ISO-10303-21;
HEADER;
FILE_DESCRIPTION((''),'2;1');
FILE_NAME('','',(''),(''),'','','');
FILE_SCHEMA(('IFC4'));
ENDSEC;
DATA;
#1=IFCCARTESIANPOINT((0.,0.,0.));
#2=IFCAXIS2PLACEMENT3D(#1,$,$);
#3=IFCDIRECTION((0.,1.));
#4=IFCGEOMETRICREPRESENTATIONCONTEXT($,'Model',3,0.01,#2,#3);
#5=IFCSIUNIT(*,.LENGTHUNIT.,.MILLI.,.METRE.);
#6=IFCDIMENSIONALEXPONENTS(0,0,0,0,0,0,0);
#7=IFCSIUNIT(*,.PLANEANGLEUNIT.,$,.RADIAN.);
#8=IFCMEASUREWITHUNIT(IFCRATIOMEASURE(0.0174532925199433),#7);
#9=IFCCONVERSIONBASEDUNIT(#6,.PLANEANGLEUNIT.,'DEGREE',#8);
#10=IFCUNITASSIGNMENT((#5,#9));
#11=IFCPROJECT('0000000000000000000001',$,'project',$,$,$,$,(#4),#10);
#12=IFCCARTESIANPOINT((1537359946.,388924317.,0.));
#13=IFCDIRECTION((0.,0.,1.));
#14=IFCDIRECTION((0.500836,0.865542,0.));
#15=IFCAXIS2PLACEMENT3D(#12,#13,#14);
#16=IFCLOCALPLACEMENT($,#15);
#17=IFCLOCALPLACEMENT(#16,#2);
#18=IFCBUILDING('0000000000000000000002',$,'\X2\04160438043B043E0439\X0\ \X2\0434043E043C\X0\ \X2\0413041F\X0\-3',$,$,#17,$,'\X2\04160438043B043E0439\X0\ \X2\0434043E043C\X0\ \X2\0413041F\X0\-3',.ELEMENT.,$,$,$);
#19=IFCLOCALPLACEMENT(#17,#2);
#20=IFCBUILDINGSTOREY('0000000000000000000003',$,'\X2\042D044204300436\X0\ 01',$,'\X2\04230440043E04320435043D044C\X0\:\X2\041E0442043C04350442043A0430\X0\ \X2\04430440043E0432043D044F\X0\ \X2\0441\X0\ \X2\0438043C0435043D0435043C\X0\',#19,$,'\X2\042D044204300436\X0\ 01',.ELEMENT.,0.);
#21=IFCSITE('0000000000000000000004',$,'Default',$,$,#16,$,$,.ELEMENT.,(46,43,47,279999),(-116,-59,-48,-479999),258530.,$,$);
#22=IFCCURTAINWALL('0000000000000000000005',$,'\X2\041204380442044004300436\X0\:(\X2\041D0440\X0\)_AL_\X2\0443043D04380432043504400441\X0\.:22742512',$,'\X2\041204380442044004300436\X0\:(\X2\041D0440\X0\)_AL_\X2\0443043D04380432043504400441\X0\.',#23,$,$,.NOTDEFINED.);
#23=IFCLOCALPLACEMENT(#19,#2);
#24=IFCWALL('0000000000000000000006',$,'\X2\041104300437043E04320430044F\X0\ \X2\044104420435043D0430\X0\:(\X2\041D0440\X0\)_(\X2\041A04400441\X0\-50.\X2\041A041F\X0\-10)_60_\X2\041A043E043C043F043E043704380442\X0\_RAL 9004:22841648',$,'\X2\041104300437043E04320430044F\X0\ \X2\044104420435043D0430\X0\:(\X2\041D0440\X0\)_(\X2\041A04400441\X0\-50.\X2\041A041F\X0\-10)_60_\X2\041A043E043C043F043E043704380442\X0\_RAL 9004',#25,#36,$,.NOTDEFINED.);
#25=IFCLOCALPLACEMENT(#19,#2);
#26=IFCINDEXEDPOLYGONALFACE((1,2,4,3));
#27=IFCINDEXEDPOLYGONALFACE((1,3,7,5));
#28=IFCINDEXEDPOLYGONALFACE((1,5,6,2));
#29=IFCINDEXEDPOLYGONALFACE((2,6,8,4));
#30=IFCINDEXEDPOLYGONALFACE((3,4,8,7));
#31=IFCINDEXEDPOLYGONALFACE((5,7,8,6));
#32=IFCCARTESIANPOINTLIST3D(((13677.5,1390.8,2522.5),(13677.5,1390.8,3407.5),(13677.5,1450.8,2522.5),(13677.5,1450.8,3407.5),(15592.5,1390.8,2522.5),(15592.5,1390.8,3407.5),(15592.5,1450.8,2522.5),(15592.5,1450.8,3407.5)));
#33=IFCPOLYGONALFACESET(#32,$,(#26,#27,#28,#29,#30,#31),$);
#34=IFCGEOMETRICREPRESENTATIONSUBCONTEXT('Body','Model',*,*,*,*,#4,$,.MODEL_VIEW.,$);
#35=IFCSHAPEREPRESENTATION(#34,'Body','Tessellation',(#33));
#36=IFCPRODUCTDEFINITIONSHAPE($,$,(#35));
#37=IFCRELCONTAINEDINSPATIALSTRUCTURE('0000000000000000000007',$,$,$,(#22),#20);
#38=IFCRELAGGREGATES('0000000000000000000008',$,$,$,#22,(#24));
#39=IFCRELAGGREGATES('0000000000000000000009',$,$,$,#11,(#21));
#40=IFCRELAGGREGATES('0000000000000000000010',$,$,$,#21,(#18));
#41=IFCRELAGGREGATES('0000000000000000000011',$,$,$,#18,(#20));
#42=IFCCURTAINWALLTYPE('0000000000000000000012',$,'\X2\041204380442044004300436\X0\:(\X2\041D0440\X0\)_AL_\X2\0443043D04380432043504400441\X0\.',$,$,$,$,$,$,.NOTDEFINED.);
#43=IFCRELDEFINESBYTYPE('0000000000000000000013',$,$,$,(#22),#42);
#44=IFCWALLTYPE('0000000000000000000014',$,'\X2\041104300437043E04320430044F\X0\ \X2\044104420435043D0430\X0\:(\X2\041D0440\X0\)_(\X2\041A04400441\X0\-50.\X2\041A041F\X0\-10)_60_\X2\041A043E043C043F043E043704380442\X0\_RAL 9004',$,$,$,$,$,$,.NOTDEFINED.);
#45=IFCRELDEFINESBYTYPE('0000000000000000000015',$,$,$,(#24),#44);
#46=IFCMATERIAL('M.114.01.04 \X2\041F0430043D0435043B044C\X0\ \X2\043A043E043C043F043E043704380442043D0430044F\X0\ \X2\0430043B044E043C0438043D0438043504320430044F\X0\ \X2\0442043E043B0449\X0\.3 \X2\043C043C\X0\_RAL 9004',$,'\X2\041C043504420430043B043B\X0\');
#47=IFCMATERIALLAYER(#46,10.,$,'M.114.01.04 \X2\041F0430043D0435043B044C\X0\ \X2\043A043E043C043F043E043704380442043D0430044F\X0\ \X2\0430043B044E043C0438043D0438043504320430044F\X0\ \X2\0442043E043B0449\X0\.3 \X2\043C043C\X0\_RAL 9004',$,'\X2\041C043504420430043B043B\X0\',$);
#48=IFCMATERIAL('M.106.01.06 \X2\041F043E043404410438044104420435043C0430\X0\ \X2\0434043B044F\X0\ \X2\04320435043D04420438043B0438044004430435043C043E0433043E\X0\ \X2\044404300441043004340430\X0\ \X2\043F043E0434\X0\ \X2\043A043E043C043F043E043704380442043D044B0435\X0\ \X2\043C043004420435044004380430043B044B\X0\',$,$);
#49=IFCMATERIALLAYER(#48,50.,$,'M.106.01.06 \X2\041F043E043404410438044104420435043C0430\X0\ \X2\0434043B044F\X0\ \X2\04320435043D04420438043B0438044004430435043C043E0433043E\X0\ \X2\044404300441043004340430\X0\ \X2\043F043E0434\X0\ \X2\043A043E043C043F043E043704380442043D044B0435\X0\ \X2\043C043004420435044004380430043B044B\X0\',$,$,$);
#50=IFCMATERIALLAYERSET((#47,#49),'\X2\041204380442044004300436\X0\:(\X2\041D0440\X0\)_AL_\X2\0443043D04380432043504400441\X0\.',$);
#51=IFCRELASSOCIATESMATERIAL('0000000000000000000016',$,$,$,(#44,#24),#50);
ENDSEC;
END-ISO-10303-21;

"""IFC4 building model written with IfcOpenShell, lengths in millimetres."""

from ifc_helpers import new_model, entity, si_unit, converted_unit, direction, frame, frame_2d, origin, place, context, subcontext, project, spatial, rectangle, extrude, material, layer, layer_set, layer_usage, type_object, element, aggregate, save


model = new_model("IFC4")

# Units and contexts
model_context = context("Model", 3, precision=0.01, world=origin(), true_north=direction((0.0, 1.0)))
body_context = subcontext(model_context, "Body", "Model", "MODEL_VIEW")
ifc_project = project(units=[si_unit("LENGTHUNIT", "METRE", prefix="MILLI"), converted_unit("PLANEANGLEUNIT", "DEGREE", entity("IfcRatioMeasure", 0.0174532925199433), si_unit("PLANEANGLEUNIT", "RADIAN"), dimensions=[0, 0, 0, 0, 0, 0, 0])], contexts=[model_context])

# Site, building, storey
site_placement = place(None, frame((1537359946.0, 388924317.0, 0.0), z_axis=(0.0, 0.0, 1.0), x_axis=(0.500836, 0.865542, 0.0)))
site = spatial("IfcSite", under=ifc_project, at=site_placement, Name="Default", CompositionType="ELEMENT", RefLatitude=(46, 43, 47, 279999), RefLongitude=(-116, -59, -48, -479999), RefElevation=258530.0)
building_placement = place(site_placement, origin())
building = spatial("IfcBuilding", under=site, at=building_placement, Name="Жилой дом ГП-3", LongName="Жилой дом ГП-3", CompositionType="ELEMENT")
storey_placement = place(building_placement, origin())
storey = spatial("IfcBuildingStorey", under=building, at=storey_placement, Name="Этаж 01", ObjectType="Уровень:Отметка уровня с именем", LongName="Этаж 01", CompositionType="ELEMENT", Elevation=0.0)

# Curtain wall, wall
curtain_wall_type = type_object("IfcCurtainWallType", Name="Витраж:(Нр)_AL_универс.", PredefinedType="NOTDEFINED")
curtain_wall_placement = place(storey_placement, origin())
curtain_wall = element("IfcCurtainWall", 1, at=curtain_wall_placement, inside=storey, type_object=curtain_wall_type, Name="Витраж:(Нр)_AL_универс.:22742512", ObjectType="Витраж:(Нр)_AL_универс.", PredefinedType="NOTDEFINED")
ifc_material_1 = material(Name="M.114.01.04 Панель композитная алюминиевая толщ.3 мм_RAL 9004", Category="Металл")
ifc_layer_1 = layer(ifc_material_1, 10.0, Name="M.114.01.04 Панель композитная алюминиевая толщ.3 мм_RAL 9004", Category="Металл")
ifc_material_2 = material(Name="M.106.01.06 Подсистема для вентилируемого фасада под композитные материалы")
ifc_layer_2 = layer(ifc_material_2, 50.0, Name="M.106.01.06 Подсистема для вентилируемого фасада под композитные материалы")
ifc_layer_set_1 = layer_set([ifc_layer_1, ifc_layer_2], Name="Витраж:(Нр)_AL_универс.")
ifc_layer_usage_1 = layer_usage(ifc_layer_set_1, "AXIS2", "NEGATIVE", 30.0)
wall_type = type_object("IfcWallType", Name="Базовая стена:(Нр)_(Крс-50.КП-10)_60_Композит_RAL 9004", PredefinedType="NOTDEFINED", material=ifc_layer_set_1)
wall_placement = place(storey_placement, frame((15592.5, 1420.8, 2522.5), z_axis=(0.0, 0.0, 1.0), x_axis=(-1.0, 0.0, 0.0)))
wall = element("IfcWall", 2, at=wall_placement, type_object=wall_type, material=ifc_layer_usage_1, Name="Базовая стена:(Нр)_(Крс-50.КП-10)_60_Композит_RAL 9004:22841648", ObjectType="Базовая стена:(Нр)_(Крс-50.КП-10)_60_Композит_RAL 9004", PredefinedType="NOTDEFINED", context=body_context, shape_type="SweptSolid", body=[
    extrude(rectangle(XDim=1915.0, YDim=60.0, at=frame_2d((957.5, 0.0), x_axis=(-1.0, 0.0))), origin(), (0.0, 0.0, 1.0), 885.0),
])
aggregate(curtain_wall, [wall])

save(model, "model.ifc")
